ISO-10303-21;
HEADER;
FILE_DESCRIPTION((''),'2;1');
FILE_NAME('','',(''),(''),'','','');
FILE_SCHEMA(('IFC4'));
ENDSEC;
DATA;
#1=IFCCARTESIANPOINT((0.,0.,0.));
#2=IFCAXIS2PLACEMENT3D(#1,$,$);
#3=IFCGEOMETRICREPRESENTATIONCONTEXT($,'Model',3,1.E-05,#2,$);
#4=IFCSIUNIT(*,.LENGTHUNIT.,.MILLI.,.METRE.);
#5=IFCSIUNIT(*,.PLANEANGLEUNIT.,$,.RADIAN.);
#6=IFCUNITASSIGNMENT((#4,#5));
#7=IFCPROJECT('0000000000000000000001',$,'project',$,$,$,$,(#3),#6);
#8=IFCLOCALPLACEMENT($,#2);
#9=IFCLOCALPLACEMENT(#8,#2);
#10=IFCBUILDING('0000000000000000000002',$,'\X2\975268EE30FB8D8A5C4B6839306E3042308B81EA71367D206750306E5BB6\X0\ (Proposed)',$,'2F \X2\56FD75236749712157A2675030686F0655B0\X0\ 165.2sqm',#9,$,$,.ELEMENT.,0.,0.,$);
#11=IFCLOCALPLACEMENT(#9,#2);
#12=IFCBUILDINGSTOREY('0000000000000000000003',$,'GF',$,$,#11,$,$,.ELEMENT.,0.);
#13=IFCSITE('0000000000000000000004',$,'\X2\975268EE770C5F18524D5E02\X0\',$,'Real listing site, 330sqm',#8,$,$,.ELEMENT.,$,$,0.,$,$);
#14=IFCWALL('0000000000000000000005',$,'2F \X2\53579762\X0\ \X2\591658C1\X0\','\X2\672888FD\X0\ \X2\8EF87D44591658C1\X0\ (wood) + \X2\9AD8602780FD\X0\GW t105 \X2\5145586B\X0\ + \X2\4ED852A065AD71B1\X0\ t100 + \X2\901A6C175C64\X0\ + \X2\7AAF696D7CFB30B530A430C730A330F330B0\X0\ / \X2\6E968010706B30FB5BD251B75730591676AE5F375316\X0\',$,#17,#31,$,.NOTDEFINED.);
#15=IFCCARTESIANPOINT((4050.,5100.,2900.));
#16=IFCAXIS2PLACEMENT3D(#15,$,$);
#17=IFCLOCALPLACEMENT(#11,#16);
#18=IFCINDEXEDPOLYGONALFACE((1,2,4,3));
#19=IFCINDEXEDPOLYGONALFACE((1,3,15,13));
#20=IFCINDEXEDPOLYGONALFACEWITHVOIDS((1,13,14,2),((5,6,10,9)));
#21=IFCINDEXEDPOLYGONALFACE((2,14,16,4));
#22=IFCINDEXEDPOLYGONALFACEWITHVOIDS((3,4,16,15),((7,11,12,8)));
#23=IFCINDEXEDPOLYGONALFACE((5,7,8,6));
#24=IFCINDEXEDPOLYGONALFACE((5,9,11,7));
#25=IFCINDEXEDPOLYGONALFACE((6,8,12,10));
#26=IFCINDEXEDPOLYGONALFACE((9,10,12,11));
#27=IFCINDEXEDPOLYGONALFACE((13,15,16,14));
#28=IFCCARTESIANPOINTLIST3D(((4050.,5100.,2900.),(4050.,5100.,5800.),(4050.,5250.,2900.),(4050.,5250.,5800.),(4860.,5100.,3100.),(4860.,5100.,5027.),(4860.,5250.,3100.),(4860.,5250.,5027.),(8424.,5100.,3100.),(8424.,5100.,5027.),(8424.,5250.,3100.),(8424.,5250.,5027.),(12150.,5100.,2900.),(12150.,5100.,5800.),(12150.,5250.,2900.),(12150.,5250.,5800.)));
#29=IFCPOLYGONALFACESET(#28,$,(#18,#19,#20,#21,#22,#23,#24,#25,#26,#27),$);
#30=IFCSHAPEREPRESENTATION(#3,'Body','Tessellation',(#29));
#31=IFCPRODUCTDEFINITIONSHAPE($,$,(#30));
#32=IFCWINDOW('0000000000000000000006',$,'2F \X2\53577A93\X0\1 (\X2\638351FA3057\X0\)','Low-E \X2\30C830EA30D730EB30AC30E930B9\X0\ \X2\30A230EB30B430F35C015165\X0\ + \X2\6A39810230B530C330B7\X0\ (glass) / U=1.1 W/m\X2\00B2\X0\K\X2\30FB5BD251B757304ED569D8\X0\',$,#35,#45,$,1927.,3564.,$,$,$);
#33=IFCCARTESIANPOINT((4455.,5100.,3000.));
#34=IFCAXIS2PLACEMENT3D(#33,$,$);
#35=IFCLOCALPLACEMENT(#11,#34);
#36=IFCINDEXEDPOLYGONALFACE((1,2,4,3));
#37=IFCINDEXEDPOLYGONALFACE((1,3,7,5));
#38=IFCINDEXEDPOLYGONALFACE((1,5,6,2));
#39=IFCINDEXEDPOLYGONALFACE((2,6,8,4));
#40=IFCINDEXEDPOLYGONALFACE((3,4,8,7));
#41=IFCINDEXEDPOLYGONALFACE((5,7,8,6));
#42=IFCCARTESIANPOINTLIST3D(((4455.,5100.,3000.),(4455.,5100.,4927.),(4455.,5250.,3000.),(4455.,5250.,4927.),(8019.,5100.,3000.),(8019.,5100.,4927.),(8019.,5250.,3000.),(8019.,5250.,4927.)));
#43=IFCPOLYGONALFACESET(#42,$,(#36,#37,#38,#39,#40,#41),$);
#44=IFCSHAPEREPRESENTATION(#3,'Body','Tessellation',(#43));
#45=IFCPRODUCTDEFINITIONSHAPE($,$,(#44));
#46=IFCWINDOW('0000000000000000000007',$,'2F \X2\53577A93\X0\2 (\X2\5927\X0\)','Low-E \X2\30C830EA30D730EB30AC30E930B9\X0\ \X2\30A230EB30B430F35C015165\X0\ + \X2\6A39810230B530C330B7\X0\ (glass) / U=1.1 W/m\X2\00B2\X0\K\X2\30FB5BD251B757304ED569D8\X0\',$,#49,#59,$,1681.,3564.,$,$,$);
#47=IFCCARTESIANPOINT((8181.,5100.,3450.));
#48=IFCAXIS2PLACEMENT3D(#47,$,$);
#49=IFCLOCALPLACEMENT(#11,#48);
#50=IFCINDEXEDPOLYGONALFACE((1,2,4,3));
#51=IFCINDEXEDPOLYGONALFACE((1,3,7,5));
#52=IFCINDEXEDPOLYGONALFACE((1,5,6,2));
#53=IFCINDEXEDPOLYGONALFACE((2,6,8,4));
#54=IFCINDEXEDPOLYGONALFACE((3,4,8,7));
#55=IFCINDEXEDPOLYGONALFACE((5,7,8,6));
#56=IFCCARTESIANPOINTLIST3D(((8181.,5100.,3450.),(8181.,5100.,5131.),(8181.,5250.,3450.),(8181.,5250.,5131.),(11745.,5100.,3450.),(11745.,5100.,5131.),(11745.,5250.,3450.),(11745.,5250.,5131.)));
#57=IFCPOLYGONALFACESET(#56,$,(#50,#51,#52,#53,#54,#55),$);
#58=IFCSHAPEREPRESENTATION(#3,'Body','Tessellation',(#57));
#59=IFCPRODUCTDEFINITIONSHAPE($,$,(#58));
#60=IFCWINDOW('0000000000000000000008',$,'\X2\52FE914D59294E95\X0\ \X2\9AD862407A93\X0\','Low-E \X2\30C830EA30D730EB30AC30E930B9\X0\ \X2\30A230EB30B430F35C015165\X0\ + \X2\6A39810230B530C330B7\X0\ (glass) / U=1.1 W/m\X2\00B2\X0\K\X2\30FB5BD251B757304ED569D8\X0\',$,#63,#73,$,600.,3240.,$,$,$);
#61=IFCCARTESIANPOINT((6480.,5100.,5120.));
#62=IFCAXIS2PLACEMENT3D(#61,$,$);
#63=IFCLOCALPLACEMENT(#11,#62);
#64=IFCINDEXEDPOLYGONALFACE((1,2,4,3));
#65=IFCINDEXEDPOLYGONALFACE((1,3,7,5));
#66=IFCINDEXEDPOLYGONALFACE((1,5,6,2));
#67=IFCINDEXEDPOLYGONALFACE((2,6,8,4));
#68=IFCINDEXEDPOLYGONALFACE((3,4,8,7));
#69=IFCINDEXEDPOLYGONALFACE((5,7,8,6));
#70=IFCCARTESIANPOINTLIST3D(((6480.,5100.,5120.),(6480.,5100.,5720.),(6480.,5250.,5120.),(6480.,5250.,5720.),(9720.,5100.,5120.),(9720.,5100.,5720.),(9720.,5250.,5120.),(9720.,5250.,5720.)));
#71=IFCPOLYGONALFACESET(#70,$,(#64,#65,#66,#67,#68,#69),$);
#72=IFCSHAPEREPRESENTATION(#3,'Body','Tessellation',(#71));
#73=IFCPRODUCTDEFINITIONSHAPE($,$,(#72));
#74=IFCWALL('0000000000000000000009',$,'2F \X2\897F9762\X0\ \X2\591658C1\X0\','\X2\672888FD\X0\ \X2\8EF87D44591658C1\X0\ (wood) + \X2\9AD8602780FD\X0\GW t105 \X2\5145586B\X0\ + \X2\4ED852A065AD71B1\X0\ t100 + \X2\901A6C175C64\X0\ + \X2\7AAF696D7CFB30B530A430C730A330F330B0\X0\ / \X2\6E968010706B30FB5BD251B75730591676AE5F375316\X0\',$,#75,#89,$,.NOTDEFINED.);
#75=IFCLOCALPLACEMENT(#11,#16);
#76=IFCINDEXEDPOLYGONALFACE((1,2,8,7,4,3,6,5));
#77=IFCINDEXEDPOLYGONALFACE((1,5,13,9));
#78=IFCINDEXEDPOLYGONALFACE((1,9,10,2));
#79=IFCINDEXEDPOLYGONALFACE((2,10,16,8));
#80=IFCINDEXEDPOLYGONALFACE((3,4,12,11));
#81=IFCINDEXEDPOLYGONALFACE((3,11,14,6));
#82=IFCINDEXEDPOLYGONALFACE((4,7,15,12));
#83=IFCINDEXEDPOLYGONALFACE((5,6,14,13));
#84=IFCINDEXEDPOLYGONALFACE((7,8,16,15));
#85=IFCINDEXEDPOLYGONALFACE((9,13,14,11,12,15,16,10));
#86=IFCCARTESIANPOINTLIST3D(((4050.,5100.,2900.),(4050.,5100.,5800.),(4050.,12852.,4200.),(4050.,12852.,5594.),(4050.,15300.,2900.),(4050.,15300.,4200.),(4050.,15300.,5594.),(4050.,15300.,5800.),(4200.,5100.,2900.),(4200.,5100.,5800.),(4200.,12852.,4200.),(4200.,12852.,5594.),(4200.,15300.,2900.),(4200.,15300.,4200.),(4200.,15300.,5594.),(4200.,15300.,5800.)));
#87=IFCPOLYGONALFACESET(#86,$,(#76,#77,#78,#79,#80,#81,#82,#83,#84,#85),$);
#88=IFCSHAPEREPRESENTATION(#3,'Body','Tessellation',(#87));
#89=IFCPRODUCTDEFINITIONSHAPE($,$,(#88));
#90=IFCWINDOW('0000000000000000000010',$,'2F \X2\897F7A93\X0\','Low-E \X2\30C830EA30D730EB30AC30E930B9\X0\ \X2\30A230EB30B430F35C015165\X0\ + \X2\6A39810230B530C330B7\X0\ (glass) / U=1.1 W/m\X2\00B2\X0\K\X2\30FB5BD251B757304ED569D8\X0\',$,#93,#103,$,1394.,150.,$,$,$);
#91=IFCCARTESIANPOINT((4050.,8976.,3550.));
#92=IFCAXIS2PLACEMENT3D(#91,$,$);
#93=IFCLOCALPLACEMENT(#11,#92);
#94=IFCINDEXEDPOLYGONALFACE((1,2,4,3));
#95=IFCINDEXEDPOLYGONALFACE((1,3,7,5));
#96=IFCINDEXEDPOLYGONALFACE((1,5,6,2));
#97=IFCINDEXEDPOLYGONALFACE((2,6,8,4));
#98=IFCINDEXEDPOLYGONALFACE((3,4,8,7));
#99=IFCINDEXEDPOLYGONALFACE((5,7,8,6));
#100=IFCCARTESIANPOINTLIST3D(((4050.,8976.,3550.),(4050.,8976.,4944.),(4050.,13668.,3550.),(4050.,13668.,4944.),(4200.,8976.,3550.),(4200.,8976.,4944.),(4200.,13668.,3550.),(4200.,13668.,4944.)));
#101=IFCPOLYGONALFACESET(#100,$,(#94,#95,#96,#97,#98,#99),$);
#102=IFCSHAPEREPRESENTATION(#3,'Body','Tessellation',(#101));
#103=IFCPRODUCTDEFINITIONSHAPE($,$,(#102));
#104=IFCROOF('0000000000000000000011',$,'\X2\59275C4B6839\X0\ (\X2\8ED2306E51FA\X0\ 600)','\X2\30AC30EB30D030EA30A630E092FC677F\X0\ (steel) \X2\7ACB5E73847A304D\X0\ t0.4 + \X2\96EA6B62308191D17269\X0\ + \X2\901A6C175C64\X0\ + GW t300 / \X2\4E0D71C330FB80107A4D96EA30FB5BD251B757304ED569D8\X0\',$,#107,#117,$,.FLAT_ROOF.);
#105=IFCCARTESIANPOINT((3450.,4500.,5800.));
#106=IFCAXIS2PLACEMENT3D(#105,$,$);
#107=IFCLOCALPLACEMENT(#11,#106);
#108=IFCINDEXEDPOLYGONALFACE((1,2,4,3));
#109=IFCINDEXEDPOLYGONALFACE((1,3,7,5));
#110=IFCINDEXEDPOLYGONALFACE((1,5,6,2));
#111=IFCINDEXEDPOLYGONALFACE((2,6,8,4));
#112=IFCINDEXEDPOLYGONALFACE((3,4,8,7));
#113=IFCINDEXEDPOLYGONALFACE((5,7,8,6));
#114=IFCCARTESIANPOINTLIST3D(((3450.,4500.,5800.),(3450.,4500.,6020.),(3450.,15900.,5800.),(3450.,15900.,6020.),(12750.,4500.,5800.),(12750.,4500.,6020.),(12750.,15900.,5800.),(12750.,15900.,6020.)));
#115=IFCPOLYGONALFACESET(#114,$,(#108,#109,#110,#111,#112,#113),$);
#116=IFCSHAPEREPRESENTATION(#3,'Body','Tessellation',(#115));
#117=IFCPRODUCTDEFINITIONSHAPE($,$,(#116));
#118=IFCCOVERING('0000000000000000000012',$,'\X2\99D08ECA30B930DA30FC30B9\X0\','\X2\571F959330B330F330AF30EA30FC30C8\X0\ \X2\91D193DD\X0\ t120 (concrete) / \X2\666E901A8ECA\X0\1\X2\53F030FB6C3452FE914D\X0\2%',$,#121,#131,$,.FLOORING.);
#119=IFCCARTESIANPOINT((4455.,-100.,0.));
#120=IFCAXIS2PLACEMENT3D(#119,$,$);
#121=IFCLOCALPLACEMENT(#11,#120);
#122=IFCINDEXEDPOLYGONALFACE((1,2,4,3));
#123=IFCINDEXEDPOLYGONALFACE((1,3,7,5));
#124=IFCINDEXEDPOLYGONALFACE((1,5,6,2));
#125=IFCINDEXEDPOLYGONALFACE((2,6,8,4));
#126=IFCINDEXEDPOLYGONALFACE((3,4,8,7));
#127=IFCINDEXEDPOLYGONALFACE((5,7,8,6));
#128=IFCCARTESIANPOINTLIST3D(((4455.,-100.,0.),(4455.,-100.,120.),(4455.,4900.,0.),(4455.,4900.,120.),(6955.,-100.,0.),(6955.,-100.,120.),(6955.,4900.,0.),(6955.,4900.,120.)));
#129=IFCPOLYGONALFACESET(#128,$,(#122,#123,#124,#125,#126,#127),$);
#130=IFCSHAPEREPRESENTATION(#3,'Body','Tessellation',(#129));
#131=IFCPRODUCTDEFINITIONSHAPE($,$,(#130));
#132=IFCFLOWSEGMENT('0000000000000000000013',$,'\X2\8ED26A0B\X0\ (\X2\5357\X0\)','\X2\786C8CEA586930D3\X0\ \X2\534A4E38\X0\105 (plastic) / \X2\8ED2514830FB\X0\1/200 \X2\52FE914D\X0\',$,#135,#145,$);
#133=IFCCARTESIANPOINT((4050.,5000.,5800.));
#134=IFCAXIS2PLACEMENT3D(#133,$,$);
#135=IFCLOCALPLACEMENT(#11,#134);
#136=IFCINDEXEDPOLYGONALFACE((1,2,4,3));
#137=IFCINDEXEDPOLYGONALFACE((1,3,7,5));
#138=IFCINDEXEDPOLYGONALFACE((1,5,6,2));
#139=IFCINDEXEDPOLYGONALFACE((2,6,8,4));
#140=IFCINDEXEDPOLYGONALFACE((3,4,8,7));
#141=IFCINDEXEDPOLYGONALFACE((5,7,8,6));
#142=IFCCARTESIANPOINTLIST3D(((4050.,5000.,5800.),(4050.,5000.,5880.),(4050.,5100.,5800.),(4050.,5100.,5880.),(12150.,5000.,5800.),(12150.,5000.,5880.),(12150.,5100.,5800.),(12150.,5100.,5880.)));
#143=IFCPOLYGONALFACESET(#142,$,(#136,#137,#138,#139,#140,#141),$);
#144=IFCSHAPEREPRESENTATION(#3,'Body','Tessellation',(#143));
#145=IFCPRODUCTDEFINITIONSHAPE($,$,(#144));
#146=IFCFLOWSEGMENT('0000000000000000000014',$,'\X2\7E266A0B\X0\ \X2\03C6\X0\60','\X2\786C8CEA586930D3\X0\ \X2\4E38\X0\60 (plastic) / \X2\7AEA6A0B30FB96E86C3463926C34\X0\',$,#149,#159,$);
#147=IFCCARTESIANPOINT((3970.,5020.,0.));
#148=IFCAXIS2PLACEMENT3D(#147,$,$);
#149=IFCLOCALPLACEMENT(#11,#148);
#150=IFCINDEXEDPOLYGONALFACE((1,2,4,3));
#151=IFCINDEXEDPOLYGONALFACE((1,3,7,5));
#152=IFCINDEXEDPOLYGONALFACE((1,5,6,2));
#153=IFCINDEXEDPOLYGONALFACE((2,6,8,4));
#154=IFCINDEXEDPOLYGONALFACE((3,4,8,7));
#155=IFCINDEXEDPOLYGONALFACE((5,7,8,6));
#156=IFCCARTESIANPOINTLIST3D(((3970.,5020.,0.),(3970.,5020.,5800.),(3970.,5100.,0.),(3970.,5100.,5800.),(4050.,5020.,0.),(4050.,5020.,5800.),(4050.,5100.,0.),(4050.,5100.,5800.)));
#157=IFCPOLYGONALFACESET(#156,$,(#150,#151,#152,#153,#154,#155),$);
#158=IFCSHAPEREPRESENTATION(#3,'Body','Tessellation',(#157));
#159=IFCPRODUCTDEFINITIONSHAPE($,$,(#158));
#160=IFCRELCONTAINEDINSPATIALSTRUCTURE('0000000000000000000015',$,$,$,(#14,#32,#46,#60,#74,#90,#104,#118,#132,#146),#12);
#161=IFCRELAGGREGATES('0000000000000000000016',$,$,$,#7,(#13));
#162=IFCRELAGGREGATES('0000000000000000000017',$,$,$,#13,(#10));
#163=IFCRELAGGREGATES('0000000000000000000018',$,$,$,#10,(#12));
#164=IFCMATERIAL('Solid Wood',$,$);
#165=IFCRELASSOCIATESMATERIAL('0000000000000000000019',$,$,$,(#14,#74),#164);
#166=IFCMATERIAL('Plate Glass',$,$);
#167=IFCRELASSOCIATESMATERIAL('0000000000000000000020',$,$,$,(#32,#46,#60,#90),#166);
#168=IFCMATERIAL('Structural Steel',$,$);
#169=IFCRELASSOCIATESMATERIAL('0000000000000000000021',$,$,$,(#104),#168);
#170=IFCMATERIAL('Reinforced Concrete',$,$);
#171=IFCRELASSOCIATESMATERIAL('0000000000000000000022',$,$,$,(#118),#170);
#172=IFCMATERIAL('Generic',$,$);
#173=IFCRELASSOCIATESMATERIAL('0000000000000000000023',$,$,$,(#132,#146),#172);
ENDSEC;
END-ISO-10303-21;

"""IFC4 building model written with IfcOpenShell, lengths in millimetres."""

from ifc_helpers import new_model, si_unit, frame, frame_2d, origin, place, context, project, spatial, rectangle, extrude, material, element, fill, save


model = new_model("IFC4")

# Units and contexts
model_context = context("Model", 3, precision=1e-05, world=origin())
ifc_project = project(units=[si_unit("LENGTHUNIT", "METRE", prefix="MILLI"), si_unit("PLANEANGLEUNIT", "RADIAN")], contexts=[model_context])

# Site, building, storey
site_placement = place(None, origin())
site = spatial("IfcSite", under=ifc_project, at=site_placement, Name="青森県弘前市", ObjectType="Real listing site, 330sqm", CompositionType="ELEMENT", RefElevation=0.0)
building_placement = place(site_placement, origin())
building = spatial("IfcBuilding", under=site, at=building_placement, Name="青森・越屋根のある自然素材の家 (Proposed)", ObjectType="2F 国産杉無垢材と漆喰 165.2sqm", CompositionType="ELEMENT", ElevationOfRefHeight=0.0, ElevationOfTerrain=0.0)
storey_placement = place(building_placement, origin())
storey = spatial("IfcBuildingStorey", under=building, at=storey_placement, Name="GF", CompositionType="ELEMENT", Elevation=0.0)

# Shared definitions
ifc_material_1 = material(Name="Solid Wood")

# Shared definitions
ifc_material_2 = material(Name="Reinforced Concrete")

# Shared definitions
ifc_material_3 = material(Name="Plate Glass")

# Wall, openings, windows
wall_1_placement = place(storey_placement, frame((4050.0, 5100.0, 2900.0)))
wall_1 = element("IfcWall", 1, at=wall_1_placement, inside=storey, material=ifc_material_1, Name="2F 南面 外壁", Description="木製 軸組外壁 (wood) + 高性能GW t105 充填 + 付加断熱 t100 + 通気層 + 窯業系サイディング / 準耐火・寒冷地外皮強化", PredefinedType="NOTDEFINED", context=model_context, shape_type="SweptSolid", body=[
    extrude(rectangle(XDim=8100.0, YDim=150.0, at=frame_2d((4050.0, 75.0))), frame((4050.0, 5100.0, 2900.0)), (0.0, 0.0, 1.0), 2900.0),
])
opening_1_placement = place(storey_placement, frame((4455.0, 5100.0, 3000.0)))
opening_1 = element("IfcOpeningElement", 2, at=opening_1_placement, cuts=wall_1, PredefinedType="NOTDEFINED", context=model_context, shape_type="SweptSolid", body=[
    extrude(rectangle(XDim=3564.0, YDim=150.0, at=frame_2d((1782.0, 75.0))), frame((4455.0, 5100.0, 3000.0)), (0.0, 0.0, 1.0), 1927.0),
])
opening_2_placement = place(storey_placement, frame((8181.0, 5100.0, 3450.0)))
opening_2 = element("IfcOpeningElement", 3, at=opening_2_placement, cuts=wall_1, PredefinedType="NOTDEFINED", context=model_context, shape_type="SweptSolid", body=[
    extrude(rectangle(XDim=3564.0, YDim=150.0, at=frame_2d((1782.0, 75.0))), frame((8181.0, 5100.0, 3450.0)), (0.0, 0.0, 1.0), 1681.0),
])
opening_3_placement = place(storey_placement, frame((6480.0, 5100.0, 5120.0)))
opening_3 = element("IfcOpeningElement", 4, at=opening_3_placement, cuts=wall_1, PredefinedType="NOTDEFINED", context=model_context, shape_type="SweptSolid", body=[
    extrude(rectangle(XDim=3240.0, YDim=150.0, at=frame_2d((1620.0, 75.0))), frame((6480.0, 5100.0, 5120.0)), (0.0, 0.0, 1.0), 600.0),
])
window_1_placement = place(storey_placement, frame((4455.0, 5100.0, 3000.0)))
window_1 = element("IfcWindow", 5, at=window_1_placement, inside=storey, material=ifc_material_3, Name="2F 南窓1 (掃出し)", Description="Low-E トリプルガラス アルゴン封入 + 樹脂サッシ (glass) / U=1.1 W/m²K・寒冷地仕様", OverallHeight=1927.0, OverallWidth=3564.0, context=model_context, shape_type="SweptSolid", body=[
    extrude(rectangle(XDim=3564.0, YDim=150.0, at=frame_2d((1782.0, 75.0))), frame((4455.0, 5100.0, 3000.0)), (0.0, 0.0, 1.0), 1927.0),
])
fill(opening_1, window_1)
window_2_placement = place(storey_placement, frame((8181.0, 5100.0, 3450.0)))
window_2 = element("IfcWindow", 6, at=window_2_placement, inside=storey, material=ifc_material_3, Name="2F 南窓2 (大)", Description="Low-E トリプルガラス アルゴン封入 + 樹脂サッシ (glass) / U=1.1 W/m²K・寒冷地仕様", OverallHeight=1681.0, OverallWidth=3564.0, context=model_context, shape_type="SweptSolid", body=[
    extrude(rectangle(XDim=3564.0, YDim=150.0, at=frame_2d((1782.0, 75.0))), frame((8181.0, 5100.0, 3450.0)), (0.0, 0.0, 1.0), 1681.0),
])
fill(opening_2, window_2)
window_3_placement = place(storey_placement, frame((6480.0, 5100.0, 5120.0)))
window_3 = element("IfcWindow", 7, at=window_3_placement, inside=storey, material=ifc_material_3, Name="勾配天井 高所窓", Description="Low-E トリプルガラス アルゴン封入 + 樹脂サッシ (glass) / U=1.1 W/m²K・寒冷地仕様", OverallHeight=600.0, OverallWidth=3240.0, context=model_context, shape_type="SweptSolid", body=[
    extrude(rectangle(XDim=3240.0, YDim=150.0, at=frame_2d((1620.0, 75.0))), frame((6480.0, 5100.0, 5120.0)), (0.0, 0.0, 1.0), 600.0),
])
fill(opening_3, window_3)

# Wall, opening, window
wall_2_placement = place(storey_placement, frame((4050.0, 5100.0, 2900.0)))
wall_2 = element("IfcWall", 8, at=wall_2_placement, inside=storey, material=ifc_material_1, Name="2F 西面 外壁", Description="木製 軸組外壁 (wood) + 高性能GW t105 充填 + 付加断熱 t100 + 通気層 + 窯業系サイディング / 準耐火・寒冷地外皮強化", PredefinedType="NOTDEFINED", context=model_context, shape_type="SweptSolid", body=[
    extrude(rectangle(XDim=150.0, YDim=10200.0, at=frame_2d((75.0, 5100.0))), frame((4050.0, 5100.0, 2900.0)), (0.0, 0.0, 1.0), 2900.0),
])
opening_4_placement = place(storey_placement, frame((4050.0, 8976.0, 3550.0)))
opening_4 = element("IfcOpeningElement", 9, at=opening_4_placement, cuts=wall_2, PredefinedType="NOTDEFINED", context=model_context, shape_type="SweptSolid", body=[
    extrude(rectangle(XDim=150.0, YDim=4692.0, at=frame_2d((75.0, 2346.0))), frame((4050.0, 8976.0, 3550.0)), (0.0, 0.0, 1.0), 1394.0),
])
window_4_placement = place(storey_placement, frame((4050.0, 8976.0, 3550.0)))
window_4 = element("IfcWindow", 10, at=window_4_placement, inside=storey, material=ifc_material_3, Name="2F 西窓", Description="Low-E トリプルガラス アルゴン封入 + 樹脂サッシ (glass) / U=1.1 W/m²K・寒冷地仕様", OverallHeight=1394.0, OverallWidth=150.0, context=model_context, shape_type="SweptSolid", body=[
    extrude(rectangle(XDim=150.0, YDim=4692.0, at=frame_2d((75.0, 2346.0))), frame((4050.0, 8976.0, 3550.0)), (0.0, 0.0, 1.0), 1394.0),
])
fill(opening_4, window_4)

# Roof
ifc_material_4 = material(Name="Structural Steel")
roof_placement = place(storey_placement, frame((3450.0, 4500.0, 5800.0)))
element("IfcRoof", 11, at=roof_placement, inside=storey, material=ifc_material_4, Name="大屋根 (軒の出 600)", Description="ガルバリウム鋼板 (steel) 立平葺き t0.4 + 雪止め金物 + 通気層 + GW t300 / 不燃・耐積雪・寒冷地仕様", PredefinedType="FLAT_ROOF", context=model_context, shape_type="SweptSolid", body=[
    extrude(rectangle(XDim=9300.0, YDim=11400.0, at=frame_2d((4650.0, 5700.0))), frame((3450.0, 4500.0, 5800.0)), (0.0, 0.0, 1.0), 220.0),
])

# Covering
covering_placement = place(storey_placement, frame((4455.0, -100.0, 0.0)))
element("IfcCovering", 12, at=covering_placement, inside=storey, material=ifc_material_2, Name="駐車スペース", Description="土間コンクリート 金鏝 t120 (concrete) / 普通車1台・水勾配2%", PredefinedType="FLOORING", context=model_context, shape_type="SweptSolid", body=[
    extrude(rectangle(XDim=2500.0, YDim=5000.0, at=frame_2d((1250.0, 2500.0))), frame((4455.0, -100.0, 0.0)), (0.0, 0.0, 1.0), 120.0),
])

# Flow segments
ifc_material_5 = material(Name="Generic")
flow_segment_1_placement = place(storey_placement, frame((4050.0, 5000.0, 5800.0)))
element("IfcFlowSegment", 13, at=flow_segment_1_placement, inside=storey, material=ifc_material_5, Name="軒樋 (南)", Description="硬質塩ビ 半丸105 (plastic) / 軒先・1/200 勾配", context=model_context, shape_type="SweptSolid", body=[
    extrude(rectangle(XDim=8100.0, YDim=100.0, at=frame_2d((4050.0, 50.0))), frame((4050.0, 5000.0, 5800.0)), (0.0, 0.0, 1.0), 80.0),
])
flow_segment_2_placement = place(storey_placement, frame((3970.0, 5020.0, 0.0)))
element("IfcFlowSegment", 14, at=flow_segment_2_placement, inside=storey, material=ifc_material_5, Name="縦樋 φ60", Description="硬質塩ビ 丸60 (plastic) / 竪樋・雨水排水", context=model_context, shape_type="SweptSolid", body=[
    extrude(rectangle(XDim=80.0, YDim=80.0, at=frame_2d((40.0, 40.0))), frame((3970.0, 5020.0, 0.0)), (0.0, 0.0, 1.0), 5800.0),
])

save(model, "model.ifc")
